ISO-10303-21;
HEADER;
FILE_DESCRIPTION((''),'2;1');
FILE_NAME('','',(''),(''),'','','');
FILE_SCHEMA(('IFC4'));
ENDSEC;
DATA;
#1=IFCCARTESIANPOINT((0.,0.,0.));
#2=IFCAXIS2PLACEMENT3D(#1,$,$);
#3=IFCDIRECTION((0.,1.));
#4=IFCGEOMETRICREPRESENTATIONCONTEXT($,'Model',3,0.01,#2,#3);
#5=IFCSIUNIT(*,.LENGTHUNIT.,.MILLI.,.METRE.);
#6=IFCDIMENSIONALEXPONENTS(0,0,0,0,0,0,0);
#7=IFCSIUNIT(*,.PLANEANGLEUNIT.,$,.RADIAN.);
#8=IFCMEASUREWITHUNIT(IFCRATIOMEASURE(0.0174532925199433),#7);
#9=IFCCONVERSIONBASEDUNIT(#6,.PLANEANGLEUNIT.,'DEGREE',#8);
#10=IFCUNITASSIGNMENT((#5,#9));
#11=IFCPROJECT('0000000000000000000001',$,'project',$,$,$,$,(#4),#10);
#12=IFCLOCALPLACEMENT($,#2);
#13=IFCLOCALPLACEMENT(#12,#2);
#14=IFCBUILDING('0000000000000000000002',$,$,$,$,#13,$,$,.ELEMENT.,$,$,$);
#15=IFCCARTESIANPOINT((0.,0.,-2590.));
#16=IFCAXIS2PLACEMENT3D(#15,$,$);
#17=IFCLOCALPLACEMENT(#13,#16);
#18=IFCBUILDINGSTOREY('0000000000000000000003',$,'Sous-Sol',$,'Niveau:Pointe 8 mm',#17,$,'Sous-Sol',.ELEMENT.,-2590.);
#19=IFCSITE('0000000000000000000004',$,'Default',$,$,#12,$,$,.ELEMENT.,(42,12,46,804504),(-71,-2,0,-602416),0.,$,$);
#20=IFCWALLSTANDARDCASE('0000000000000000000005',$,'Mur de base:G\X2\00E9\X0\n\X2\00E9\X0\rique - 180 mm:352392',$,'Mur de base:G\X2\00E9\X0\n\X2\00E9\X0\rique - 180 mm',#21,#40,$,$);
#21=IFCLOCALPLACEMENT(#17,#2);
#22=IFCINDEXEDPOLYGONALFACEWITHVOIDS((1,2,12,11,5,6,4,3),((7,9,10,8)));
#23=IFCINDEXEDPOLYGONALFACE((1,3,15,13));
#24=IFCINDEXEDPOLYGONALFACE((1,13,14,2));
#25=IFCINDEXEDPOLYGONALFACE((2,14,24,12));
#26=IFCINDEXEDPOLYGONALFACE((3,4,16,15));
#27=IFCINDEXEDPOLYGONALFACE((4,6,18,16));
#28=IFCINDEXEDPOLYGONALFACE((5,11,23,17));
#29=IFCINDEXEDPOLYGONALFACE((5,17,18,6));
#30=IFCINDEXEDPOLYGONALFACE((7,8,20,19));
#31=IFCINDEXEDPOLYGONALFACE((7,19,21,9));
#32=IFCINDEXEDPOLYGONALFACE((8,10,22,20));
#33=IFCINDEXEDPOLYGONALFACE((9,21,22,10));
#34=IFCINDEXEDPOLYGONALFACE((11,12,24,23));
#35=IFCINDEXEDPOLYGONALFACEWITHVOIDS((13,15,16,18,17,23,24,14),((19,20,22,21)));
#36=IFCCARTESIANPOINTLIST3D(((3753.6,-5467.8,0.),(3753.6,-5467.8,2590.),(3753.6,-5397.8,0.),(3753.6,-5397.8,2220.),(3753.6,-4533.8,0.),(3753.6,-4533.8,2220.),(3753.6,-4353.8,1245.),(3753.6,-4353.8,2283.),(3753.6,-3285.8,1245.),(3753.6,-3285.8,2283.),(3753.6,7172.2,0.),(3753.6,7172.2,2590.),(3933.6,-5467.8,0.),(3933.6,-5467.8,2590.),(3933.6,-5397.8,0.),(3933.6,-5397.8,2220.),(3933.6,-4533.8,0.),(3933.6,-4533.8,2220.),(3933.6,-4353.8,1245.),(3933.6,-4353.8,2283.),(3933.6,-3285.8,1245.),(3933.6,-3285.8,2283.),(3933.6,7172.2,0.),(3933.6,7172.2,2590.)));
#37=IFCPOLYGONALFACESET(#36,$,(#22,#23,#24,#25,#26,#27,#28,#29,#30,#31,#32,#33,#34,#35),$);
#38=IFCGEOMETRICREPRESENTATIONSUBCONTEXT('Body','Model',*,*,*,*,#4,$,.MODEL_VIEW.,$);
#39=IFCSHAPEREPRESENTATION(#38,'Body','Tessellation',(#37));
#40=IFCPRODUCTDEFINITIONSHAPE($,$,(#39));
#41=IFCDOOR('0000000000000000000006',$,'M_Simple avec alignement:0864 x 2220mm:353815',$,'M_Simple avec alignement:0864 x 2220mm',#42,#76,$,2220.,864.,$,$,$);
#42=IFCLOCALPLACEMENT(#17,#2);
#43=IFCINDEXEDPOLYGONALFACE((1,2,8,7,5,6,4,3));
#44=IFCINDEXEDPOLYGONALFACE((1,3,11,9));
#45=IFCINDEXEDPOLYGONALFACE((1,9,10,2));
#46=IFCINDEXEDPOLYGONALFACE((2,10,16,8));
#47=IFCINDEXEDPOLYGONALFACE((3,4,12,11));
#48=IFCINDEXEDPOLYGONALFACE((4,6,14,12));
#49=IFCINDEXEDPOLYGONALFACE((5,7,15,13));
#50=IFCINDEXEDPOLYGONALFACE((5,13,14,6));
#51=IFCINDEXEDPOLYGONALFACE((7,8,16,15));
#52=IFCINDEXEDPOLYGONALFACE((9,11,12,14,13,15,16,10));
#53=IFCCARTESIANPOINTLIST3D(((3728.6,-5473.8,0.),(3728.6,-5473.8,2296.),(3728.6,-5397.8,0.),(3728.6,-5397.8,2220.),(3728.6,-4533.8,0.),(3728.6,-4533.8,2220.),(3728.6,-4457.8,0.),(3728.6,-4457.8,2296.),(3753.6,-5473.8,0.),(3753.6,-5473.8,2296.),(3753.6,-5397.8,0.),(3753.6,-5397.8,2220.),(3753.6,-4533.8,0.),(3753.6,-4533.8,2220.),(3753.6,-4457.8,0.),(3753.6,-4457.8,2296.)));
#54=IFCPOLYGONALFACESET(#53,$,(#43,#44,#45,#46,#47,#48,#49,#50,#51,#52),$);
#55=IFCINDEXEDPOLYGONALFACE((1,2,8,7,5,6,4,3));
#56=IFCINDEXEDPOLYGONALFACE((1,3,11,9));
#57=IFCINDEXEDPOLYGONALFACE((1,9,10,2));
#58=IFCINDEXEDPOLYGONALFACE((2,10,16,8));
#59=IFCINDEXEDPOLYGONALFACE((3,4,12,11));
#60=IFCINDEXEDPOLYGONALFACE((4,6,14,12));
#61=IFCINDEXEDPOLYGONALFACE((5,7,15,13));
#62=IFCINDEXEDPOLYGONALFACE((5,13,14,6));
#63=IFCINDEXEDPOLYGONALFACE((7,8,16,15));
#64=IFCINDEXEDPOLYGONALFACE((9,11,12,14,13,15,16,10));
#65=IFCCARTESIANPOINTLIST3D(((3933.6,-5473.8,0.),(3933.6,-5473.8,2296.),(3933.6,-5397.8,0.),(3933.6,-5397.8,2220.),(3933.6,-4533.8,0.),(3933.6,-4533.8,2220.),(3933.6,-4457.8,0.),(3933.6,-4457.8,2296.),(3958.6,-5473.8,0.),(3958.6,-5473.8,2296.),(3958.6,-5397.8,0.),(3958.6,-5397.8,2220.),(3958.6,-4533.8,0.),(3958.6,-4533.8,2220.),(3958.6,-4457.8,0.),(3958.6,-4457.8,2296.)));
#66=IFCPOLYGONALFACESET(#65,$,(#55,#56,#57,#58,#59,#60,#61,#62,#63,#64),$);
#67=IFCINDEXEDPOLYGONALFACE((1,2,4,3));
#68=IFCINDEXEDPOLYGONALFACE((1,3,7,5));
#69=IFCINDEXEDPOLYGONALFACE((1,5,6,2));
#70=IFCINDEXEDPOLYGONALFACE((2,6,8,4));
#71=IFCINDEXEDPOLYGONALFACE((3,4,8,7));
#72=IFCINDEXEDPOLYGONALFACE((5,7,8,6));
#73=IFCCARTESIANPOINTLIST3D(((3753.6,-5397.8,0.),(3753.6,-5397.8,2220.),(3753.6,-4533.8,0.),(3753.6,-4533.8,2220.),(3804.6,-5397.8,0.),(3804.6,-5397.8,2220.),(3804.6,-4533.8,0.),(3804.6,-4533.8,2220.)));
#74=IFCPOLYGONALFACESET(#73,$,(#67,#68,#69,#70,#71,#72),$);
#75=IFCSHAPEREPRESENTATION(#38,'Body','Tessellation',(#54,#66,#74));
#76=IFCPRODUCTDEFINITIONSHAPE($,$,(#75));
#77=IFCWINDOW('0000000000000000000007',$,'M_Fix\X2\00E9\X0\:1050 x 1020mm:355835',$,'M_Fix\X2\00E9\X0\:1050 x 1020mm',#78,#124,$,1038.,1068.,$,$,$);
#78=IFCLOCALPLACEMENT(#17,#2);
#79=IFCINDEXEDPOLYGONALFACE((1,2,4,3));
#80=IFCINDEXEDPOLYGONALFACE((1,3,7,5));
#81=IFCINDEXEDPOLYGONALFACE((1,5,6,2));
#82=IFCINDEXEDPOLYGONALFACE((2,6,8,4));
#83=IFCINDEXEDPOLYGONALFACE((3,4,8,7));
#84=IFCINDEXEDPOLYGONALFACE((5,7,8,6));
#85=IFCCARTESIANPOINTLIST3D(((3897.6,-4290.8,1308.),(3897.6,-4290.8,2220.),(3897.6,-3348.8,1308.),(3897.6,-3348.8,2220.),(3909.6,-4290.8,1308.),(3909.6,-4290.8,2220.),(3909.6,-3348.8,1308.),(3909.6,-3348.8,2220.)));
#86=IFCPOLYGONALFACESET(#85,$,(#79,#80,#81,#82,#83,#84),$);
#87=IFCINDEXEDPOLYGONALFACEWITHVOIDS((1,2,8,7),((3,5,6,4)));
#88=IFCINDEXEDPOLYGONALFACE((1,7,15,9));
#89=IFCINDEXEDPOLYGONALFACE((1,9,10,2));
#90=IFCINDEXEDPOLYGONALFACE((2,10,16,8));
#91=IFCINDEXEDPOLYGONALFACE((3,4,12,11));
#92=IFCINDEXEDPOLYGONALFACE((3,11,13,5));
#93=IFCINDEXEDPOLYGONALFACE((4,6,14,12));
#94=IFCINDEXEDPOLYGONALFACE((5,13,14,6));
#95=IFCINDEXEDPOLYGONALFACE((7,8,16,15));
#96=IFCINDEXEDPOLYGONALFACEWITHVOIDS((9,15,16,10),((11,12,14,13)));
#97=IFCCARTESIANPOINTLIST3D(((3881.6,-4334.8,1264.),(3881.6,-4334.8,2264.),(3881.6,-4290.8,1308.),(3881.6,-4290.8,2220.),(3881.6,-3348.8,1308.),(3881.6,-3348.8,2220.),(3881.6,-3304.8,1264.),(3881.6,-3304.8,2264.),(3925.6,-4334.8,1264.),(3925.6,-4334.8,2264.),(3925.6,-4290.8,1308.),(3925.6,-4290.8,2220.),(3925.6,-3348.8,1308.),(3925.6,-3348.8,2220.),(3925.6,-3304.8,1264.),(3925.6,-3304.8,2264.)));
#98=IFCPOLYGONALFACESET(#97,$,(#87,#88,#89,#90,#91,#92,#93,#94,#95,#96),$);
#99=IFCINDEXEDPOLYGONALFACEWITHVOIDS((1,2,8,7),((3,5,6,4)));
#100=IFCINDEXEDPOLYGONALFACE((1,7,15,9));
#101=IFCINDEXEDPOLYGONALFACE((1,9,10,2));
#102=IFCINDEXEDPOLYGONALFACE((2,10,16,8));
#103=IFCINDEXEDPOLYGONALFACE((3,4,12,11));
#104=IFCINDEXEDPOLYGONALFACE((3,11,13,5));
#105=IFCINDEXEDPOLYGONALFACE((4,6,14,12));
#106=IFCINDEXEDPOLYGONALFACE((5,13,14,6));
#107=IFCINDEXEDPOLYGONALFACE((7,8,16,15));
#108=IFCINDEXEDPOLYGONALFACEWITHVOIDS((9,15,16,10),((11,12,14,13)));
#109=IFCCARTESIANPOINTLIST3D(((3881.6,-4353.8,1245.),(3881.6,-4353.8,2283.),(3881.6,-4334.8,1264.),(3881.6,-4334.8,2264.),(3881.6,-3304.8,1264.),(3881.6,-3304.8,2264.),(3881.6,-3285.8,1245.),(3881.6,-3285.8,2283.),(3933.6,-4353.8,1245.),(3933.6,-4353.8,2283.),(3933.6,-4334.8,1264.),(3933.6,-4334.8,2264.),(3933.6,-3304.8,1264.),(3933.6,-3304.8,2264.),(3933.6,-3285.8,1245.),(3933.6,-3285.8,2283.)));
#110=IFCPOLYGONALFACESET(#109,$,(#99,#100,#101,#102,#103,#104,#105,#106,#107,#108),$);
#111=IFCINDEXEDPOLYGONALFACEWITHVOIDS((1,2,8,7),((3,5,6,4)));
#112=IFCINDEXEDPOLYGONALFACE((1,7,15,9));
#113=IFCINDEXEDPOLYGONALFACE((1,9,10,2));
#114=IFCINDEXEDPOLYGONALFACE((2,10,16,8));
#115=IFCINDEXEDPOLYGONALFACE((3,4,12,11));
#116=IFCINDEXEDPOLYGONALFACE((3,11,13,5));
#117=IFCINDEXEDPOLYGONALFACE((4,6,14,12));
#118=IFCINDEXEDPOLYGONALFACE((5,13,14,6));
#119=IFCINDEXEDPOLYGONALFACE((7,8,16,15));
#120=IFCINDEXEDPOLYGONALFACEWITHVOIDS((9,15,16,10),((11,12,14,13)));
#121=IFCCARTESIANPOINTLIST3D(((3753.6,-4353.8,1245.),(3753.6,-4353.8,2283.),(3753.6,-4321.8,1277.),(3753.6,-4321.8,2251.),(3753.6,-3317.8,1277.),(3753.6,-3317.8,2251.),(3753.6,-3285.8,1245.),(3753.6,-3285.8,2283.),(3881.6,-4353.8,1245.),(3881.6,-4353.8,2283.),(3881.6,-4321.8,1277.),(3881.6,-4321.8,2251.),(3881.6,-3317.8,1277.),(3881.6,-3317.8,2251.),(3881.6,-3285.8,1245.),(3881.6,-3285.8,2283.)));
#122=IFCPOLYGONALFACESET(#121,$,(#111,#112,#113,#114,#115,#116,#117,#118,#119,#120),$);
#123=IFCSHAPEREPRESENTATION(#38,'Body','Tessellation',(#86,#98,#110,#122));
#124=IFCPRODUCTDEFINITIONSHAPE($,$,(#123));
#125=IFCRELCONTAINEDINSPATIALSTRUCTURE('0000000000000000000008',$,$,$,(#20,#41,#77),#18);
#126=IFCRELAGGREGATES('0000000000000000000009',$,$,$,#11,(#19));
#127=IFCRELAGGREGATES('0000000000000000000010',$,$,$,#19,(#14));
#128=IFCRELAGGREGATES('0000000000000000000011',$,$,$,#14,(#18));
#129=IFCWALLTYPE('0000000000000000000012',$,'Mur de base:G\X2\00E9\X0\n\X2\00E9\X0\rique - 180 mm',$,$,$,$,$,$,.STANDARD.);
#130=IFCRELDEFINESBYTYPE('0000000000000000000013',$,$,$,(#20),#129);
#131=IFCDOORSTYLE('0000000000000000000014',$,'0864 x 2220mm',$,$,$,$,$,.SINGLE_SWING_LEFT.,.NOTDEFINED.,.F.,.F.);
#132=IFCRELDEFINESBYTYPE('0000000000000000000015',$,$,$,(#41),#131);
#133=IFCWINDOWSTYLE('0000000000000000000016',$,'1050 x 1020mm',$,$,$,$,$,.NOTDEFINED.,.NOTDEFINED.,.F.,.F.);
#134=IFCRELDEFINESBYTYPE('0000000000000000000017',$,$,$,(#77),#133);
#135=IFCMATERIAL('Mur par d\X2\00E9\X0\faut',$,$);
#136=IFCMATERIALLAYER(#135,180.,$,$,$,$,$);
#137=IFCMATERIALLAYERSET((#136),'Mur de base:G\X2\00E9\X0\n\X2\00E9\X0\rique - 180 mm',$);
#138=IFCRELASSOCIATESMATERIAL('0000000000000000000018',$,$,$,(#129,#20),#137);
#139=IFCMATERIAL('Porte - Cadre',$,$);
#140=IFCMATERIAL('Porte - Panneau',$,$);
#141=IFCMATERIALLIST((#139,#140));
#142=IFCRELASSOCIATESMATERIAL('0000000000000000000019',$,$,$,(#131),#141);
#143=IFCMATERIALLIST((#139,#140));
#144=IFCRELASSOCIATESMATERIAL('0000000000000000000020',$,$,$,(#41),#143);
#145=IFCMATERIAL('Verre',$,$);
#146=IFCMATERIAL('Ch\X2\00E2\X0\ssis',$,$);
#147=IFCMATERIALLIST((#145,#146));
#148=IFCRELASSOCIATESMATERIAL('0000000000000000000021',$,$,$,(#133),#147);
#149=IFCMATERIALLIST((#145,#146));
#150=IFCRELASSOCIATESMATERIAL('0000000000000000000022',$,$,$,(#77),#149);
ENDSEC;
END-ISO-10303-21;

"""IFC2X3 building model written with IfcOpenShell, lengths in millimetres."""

from ifc_helpers import new_model, entity, si_unit, converted_unit, direction, frame, frame_2d, origin, place, context, subcontext, project, spatial, polyline, rectangle, outline, extrude, source, transform, mapped, material, material_list, layer, layer_set, layer_usage, type_object, type_shapes, element, fill, save


model = new_model("IFC2X3")

# Units and contexts
model_context = context("Model", 3, precision=0.01, world=origin(), true_north=direction((0.0, 1.0)))
body_context = subcontext(model_context, "Body", "Model", "MODEL_VIEW")
ifc_project = project(units=[si_unit("LENGTHUNIT", "METRE", prefix="MILLI"), converted_unit("PLANEANGLEUNIT", "DEGREE", entity("IfcRatioMeasure", 0.0174532925199433), si_unit("PLANEANGLEUNIT", "RADIAN"), dimensions=[0, 0, 0, 0, 0, 0, 0])], contexts=[model_context])

# Site, building, storey
site_placement = place(None, origin())
site = spatial("IfcSite", under=ifc_project, at=site_placement, Name="Default", CompositionType="ELEMENT", RefLatitude=(42, 12, 46, 804504), RefLongitude=(-71, -2, 0, -602416), RefElevation=0.0)
building_placement = place(site_placement, origin())
building = spatial("IfcBuilding", under=site, at=building_placement, CompositionType="ELEMENT")
storey_placement = place(building_placement, frame((0.0, 0.0, -2590.0)))
storey = spatial("IfcBuildingStorey", under=building, at=storey_placement, Name="Sous-Sol", ObjectType="Niveau:Pointe 8 mm", LongName="Sous-Sol", CompositionType="ELEMENT", Elevation=-2590.0)

# Shared definitions
ifc_material_1 = material(Name="Mur par défaut")
ifc_layer_1 = layer(ifc_material_1, 180.0)
ifc_layer_set_1 = layer_set([ifc_layer_1], Name="Mur de base:Générique - 180 mm")
wall_type_1 = type_object("IfcWallType", Name="Mur de base:Générique - 180 mm", PredefinedType="STANDARD", material=ifc_layer_set_1)
ifc_material_2 = material(Name="Verre")
ifc_material_3 = material(Name="Châssis")

# Wall, openings, door, window
ifc_layer_usage_1 = layer_usage(ifc_layer_set_1, "AXIS2", "NEGATIVE", 90.0)
wall_1_placement = place(storey_placement, frame((3843.6, -5467.8, 0.0), z_axis=(0.0, 0.0, 1.0), x_axis=(0.0, 1.0, 0.0)))
wall_1 = element("IfcWallStandardCase", 1, at=wall_1_placement, inside=storey, type_object=wall_type_1, material=ifc_layer_usage_1, Name="Mur de base:Générique - 180 mm:352392", ObjectType="Mur de base:Générique - 180 mm", context=body_context, shape_type="SweptSolid", body=[
    extrude(rectangle(XDim=12640.0, YDim=180.0, at=frame_2d((6320.0, 0.0), x_axis=(-1.0, 0.0))), origin(), (0.0, 0.0, 1.0), 2590.0),
])
opening_1_placement = place(wall_1_placement, frame((70.0, -90.0, 0.0)))
opening_1 = element("IfcOpeningElement", 2, at=opening_1_placement, cuts=wall_1, ObjectType="Opening", context=body_context, shape_type="SweptSolid", body=[
    extrude(rectangle(XDim=864.0, YDim=2220.0, at=frame_2d((1110.0, 432.0), x_axis=(0.0, -1.0))), frame((0.0, 0.0, 0.0), z_axis=(0.0, 1.0, 0.0), x_axis=(0.0, 0.0, 1.0)), (0.0, 0.0, 1.0), 180.0),
])
opening_2_placement = place(wall_1_placement, frame((2182.0, 90.0, 1245.0)))
opening_2 = element("IfcOpeningElement", 3, at=opening_2_placement, cuts=wall_1, ObjectType="Opening", context=body_context, shape_type="SweptSolid", body=[
    extrude(rectangle(XDim=1038.0, YDim=1068.0, at=frame_2d((519.0, 534.0), x_axis=(1.0, 0.0))), frame((0.0, 0.0, 0.0), z_axis=(0.0, -1.0, 0.0), x_axis=(0.0, 0.0, 1.0)), (0.0, 0.0, 1.0), 180.0),
])
ifc_material_4 = material(Name="Porte - Cadre")
ifc_material_5 = material(Name="Porte - Panneau")
ifc_material_list_1 = material_list([ifc_material_4, ifc_material_5])
ifc_material_list_2 = material_list([ifc_material_4, ifc_material_5])
door_style_1 = type_object("IfcDoorStyle", Name="0864 x 2220mm", ConstructionType="NOTDEFINED", OperationType="SINGLE_SWING_LEFT", ParameterTakesPrecedence=False, Sizeable=False, material=ifc_material_list_2)
shared_shape_1 = source(origin(), body_context, "Body", "SweptSolid", [
    extrude(outline(polyline([(-508.0, -1167.0), (508.0, -1167.0), (508.0, 1129.0), (432.0, 1129.0), (432.0, -1091.0), (-432.0, -1091.0), (-432.0, 1129.0), (-508.0, 1129.0), (-508.0, -1167.0)])), frame((432.0, 205.0, 1129.0), z_axis=(0.0, -1.0, 0.0), x_axis=(-1.0, 0.0, 0.0)), (0.0, 0.0, 1.0), 25.0),
    extrude(outline(polyline([(-1167.0, -508.0), (1129.0, -508.0), (1129.0, -432.0), (-1091.0, -432.0), (-1091.0, 432.0), (1129.0, 432.0), (1129.0, 508.0), (-1167.0, 508.0), (-1167.0, -508.0)])), frame((432.0, 0.0, 1129.0), z_axis=(0.0, -1.0, 0.0), x_axis=(0.0, 0.0, -1.0)), (0.0, 0.0, 1.0), 25.0),
    extrude(rectangle(XDim=864.0, YDim=51.0, at=frame_2d((0.0, 0.0), x_axis=(1.0, 0.0))), frame((432.0, 154.5, 0.0)), (0.0, 0.0, 1.0), 2220.0),
])
type_shapes(door_style_1, [shared_shape_1])
door_1_placement = place(opening_1_placement, origin())
door_1 = element("IfcDoor", 4, at=door_1_placement, inside=storey, type_object=door_style_1, material=ifc_material_list_1, Name="M_Simple avec alignement:0864 x 2220mm:353815", ObjectType="M_Simple avec alignement:0864 x 2220mm", OverallHeight=2220.0, OverallWidth=864.0, context=body_context, shape_type="MappedRepresentation", body=[
    mapped(shared_shape_1, transform((0.0, 0.0, 0.0), scale=1.0)),
])
fill(opening_1, door_1)
ifc_material_list_3 = material_list([ifc_material_2, ifc_material_3])
ifc_material_list_4 = material_list([ifc_material_2, ifc_material_3])
window_style_1 = type_object("IfcWindowStyle", Name="1050 x 1020mm", ConstructionType="NOTDEFINED", OperationType="NOTDEFINED", ParameterTakesPrecedence=False, Sizeable=False, material=ifc_material_list_4)
shared_shape_2 = source(origin(), body_context, "Body", "SweptSolid", [
    extrude(rectangle(XDim=12.0, YDim=942.0, at=frame_2d((0.0, 0.0), x_axis=(1.0, 0.0))), frame((534.0, 150.0, 63.0), z_axis=(0.0, 0.0, 1.0), x_axis=(0.0, -1.0, 0.0)), (0.0, 0.0, 1.0), 912.0),
    extrude(outline(polyline([(-515.0, -500.0), (515.0, -500.0), (515.0, 500.0), (-515.0, 500.0), (-515.0, -500.0)]), holes=[polyline([(-471.0, -456.0), (-471.0, 456.0), (471.0, 456.0), (471.0, -456.0), (-471.0, -456.0)])]), frame((534.0, 128.0, 519.0), z_axis=(0.0, 1.0, 0.0), x_axis=(1.0, 0.0, 0.0)), (0.0, 0.0, 1.0), 44.0),
    extrude(outline(polyline([(-534.0, -519.0), (534.0, -519.0), (534.0, 519.0), (-534.0, 519.0), (-534.0, -519.0)]), holes=[polyline([(-515.0, -500.0), (-515.0, 500.0), (515.0, 500.0), (515.0, -500.0), (-515.0, -500.0)])]), frame((534.0, 128.0, 519.0), z_axis=(0.0, 1.0, 0.0), x_axis=(1.0, 0.0, 0.0)), (0.0, 0.0, 1.0), 52.0),
    extrude(outline(polyline([(-534.0, -519.0), (534.0, -519.0), (534.0, 519.0), (-534.0, 519.0), (-534.0, -519.0)]), holes=[polyline([(-502.0, -487.0), (-502.0, 487.0), (502.0, 487.0), (502.0, -487.0), (-502.0, -487.0)])]), frame((534.0, 0.0, 519.0), z_axis=(0.0, 1.0, 0.0), x_axis=(1.0, 0.0, 0.0)), (0.0, 0.0, 1.0), 128.0),
])
type_shapes(window_style_1, [shared_shape_2])
window_1_placement = place(opening_2_placement, frame((0.0, 0.0, 0.0), z_axis=(0.0, 0.0, 1.0), x_axis=(-1.0, 0.0, 0.0)))
window_1 = element("IfcWindow", 5, at=window_1_placement, inside=storey, type_object=window_style_1, material=ifc_material_list_3, Name="M_Fixé:1050 x 1020mm:355835", ObjectType="M_Fixé:1050 x 1020mm", OverallHeight=1038.0, OverallWidth=1068.0, context=body_context, shape_type="MappedRepresentation", body=[
    mapped(shared_shape_2, transform((0.0, 0.0, 0.0), scale=1.0)),
])
fill(opening_2, window_1)

save(model, "model.ifc")
